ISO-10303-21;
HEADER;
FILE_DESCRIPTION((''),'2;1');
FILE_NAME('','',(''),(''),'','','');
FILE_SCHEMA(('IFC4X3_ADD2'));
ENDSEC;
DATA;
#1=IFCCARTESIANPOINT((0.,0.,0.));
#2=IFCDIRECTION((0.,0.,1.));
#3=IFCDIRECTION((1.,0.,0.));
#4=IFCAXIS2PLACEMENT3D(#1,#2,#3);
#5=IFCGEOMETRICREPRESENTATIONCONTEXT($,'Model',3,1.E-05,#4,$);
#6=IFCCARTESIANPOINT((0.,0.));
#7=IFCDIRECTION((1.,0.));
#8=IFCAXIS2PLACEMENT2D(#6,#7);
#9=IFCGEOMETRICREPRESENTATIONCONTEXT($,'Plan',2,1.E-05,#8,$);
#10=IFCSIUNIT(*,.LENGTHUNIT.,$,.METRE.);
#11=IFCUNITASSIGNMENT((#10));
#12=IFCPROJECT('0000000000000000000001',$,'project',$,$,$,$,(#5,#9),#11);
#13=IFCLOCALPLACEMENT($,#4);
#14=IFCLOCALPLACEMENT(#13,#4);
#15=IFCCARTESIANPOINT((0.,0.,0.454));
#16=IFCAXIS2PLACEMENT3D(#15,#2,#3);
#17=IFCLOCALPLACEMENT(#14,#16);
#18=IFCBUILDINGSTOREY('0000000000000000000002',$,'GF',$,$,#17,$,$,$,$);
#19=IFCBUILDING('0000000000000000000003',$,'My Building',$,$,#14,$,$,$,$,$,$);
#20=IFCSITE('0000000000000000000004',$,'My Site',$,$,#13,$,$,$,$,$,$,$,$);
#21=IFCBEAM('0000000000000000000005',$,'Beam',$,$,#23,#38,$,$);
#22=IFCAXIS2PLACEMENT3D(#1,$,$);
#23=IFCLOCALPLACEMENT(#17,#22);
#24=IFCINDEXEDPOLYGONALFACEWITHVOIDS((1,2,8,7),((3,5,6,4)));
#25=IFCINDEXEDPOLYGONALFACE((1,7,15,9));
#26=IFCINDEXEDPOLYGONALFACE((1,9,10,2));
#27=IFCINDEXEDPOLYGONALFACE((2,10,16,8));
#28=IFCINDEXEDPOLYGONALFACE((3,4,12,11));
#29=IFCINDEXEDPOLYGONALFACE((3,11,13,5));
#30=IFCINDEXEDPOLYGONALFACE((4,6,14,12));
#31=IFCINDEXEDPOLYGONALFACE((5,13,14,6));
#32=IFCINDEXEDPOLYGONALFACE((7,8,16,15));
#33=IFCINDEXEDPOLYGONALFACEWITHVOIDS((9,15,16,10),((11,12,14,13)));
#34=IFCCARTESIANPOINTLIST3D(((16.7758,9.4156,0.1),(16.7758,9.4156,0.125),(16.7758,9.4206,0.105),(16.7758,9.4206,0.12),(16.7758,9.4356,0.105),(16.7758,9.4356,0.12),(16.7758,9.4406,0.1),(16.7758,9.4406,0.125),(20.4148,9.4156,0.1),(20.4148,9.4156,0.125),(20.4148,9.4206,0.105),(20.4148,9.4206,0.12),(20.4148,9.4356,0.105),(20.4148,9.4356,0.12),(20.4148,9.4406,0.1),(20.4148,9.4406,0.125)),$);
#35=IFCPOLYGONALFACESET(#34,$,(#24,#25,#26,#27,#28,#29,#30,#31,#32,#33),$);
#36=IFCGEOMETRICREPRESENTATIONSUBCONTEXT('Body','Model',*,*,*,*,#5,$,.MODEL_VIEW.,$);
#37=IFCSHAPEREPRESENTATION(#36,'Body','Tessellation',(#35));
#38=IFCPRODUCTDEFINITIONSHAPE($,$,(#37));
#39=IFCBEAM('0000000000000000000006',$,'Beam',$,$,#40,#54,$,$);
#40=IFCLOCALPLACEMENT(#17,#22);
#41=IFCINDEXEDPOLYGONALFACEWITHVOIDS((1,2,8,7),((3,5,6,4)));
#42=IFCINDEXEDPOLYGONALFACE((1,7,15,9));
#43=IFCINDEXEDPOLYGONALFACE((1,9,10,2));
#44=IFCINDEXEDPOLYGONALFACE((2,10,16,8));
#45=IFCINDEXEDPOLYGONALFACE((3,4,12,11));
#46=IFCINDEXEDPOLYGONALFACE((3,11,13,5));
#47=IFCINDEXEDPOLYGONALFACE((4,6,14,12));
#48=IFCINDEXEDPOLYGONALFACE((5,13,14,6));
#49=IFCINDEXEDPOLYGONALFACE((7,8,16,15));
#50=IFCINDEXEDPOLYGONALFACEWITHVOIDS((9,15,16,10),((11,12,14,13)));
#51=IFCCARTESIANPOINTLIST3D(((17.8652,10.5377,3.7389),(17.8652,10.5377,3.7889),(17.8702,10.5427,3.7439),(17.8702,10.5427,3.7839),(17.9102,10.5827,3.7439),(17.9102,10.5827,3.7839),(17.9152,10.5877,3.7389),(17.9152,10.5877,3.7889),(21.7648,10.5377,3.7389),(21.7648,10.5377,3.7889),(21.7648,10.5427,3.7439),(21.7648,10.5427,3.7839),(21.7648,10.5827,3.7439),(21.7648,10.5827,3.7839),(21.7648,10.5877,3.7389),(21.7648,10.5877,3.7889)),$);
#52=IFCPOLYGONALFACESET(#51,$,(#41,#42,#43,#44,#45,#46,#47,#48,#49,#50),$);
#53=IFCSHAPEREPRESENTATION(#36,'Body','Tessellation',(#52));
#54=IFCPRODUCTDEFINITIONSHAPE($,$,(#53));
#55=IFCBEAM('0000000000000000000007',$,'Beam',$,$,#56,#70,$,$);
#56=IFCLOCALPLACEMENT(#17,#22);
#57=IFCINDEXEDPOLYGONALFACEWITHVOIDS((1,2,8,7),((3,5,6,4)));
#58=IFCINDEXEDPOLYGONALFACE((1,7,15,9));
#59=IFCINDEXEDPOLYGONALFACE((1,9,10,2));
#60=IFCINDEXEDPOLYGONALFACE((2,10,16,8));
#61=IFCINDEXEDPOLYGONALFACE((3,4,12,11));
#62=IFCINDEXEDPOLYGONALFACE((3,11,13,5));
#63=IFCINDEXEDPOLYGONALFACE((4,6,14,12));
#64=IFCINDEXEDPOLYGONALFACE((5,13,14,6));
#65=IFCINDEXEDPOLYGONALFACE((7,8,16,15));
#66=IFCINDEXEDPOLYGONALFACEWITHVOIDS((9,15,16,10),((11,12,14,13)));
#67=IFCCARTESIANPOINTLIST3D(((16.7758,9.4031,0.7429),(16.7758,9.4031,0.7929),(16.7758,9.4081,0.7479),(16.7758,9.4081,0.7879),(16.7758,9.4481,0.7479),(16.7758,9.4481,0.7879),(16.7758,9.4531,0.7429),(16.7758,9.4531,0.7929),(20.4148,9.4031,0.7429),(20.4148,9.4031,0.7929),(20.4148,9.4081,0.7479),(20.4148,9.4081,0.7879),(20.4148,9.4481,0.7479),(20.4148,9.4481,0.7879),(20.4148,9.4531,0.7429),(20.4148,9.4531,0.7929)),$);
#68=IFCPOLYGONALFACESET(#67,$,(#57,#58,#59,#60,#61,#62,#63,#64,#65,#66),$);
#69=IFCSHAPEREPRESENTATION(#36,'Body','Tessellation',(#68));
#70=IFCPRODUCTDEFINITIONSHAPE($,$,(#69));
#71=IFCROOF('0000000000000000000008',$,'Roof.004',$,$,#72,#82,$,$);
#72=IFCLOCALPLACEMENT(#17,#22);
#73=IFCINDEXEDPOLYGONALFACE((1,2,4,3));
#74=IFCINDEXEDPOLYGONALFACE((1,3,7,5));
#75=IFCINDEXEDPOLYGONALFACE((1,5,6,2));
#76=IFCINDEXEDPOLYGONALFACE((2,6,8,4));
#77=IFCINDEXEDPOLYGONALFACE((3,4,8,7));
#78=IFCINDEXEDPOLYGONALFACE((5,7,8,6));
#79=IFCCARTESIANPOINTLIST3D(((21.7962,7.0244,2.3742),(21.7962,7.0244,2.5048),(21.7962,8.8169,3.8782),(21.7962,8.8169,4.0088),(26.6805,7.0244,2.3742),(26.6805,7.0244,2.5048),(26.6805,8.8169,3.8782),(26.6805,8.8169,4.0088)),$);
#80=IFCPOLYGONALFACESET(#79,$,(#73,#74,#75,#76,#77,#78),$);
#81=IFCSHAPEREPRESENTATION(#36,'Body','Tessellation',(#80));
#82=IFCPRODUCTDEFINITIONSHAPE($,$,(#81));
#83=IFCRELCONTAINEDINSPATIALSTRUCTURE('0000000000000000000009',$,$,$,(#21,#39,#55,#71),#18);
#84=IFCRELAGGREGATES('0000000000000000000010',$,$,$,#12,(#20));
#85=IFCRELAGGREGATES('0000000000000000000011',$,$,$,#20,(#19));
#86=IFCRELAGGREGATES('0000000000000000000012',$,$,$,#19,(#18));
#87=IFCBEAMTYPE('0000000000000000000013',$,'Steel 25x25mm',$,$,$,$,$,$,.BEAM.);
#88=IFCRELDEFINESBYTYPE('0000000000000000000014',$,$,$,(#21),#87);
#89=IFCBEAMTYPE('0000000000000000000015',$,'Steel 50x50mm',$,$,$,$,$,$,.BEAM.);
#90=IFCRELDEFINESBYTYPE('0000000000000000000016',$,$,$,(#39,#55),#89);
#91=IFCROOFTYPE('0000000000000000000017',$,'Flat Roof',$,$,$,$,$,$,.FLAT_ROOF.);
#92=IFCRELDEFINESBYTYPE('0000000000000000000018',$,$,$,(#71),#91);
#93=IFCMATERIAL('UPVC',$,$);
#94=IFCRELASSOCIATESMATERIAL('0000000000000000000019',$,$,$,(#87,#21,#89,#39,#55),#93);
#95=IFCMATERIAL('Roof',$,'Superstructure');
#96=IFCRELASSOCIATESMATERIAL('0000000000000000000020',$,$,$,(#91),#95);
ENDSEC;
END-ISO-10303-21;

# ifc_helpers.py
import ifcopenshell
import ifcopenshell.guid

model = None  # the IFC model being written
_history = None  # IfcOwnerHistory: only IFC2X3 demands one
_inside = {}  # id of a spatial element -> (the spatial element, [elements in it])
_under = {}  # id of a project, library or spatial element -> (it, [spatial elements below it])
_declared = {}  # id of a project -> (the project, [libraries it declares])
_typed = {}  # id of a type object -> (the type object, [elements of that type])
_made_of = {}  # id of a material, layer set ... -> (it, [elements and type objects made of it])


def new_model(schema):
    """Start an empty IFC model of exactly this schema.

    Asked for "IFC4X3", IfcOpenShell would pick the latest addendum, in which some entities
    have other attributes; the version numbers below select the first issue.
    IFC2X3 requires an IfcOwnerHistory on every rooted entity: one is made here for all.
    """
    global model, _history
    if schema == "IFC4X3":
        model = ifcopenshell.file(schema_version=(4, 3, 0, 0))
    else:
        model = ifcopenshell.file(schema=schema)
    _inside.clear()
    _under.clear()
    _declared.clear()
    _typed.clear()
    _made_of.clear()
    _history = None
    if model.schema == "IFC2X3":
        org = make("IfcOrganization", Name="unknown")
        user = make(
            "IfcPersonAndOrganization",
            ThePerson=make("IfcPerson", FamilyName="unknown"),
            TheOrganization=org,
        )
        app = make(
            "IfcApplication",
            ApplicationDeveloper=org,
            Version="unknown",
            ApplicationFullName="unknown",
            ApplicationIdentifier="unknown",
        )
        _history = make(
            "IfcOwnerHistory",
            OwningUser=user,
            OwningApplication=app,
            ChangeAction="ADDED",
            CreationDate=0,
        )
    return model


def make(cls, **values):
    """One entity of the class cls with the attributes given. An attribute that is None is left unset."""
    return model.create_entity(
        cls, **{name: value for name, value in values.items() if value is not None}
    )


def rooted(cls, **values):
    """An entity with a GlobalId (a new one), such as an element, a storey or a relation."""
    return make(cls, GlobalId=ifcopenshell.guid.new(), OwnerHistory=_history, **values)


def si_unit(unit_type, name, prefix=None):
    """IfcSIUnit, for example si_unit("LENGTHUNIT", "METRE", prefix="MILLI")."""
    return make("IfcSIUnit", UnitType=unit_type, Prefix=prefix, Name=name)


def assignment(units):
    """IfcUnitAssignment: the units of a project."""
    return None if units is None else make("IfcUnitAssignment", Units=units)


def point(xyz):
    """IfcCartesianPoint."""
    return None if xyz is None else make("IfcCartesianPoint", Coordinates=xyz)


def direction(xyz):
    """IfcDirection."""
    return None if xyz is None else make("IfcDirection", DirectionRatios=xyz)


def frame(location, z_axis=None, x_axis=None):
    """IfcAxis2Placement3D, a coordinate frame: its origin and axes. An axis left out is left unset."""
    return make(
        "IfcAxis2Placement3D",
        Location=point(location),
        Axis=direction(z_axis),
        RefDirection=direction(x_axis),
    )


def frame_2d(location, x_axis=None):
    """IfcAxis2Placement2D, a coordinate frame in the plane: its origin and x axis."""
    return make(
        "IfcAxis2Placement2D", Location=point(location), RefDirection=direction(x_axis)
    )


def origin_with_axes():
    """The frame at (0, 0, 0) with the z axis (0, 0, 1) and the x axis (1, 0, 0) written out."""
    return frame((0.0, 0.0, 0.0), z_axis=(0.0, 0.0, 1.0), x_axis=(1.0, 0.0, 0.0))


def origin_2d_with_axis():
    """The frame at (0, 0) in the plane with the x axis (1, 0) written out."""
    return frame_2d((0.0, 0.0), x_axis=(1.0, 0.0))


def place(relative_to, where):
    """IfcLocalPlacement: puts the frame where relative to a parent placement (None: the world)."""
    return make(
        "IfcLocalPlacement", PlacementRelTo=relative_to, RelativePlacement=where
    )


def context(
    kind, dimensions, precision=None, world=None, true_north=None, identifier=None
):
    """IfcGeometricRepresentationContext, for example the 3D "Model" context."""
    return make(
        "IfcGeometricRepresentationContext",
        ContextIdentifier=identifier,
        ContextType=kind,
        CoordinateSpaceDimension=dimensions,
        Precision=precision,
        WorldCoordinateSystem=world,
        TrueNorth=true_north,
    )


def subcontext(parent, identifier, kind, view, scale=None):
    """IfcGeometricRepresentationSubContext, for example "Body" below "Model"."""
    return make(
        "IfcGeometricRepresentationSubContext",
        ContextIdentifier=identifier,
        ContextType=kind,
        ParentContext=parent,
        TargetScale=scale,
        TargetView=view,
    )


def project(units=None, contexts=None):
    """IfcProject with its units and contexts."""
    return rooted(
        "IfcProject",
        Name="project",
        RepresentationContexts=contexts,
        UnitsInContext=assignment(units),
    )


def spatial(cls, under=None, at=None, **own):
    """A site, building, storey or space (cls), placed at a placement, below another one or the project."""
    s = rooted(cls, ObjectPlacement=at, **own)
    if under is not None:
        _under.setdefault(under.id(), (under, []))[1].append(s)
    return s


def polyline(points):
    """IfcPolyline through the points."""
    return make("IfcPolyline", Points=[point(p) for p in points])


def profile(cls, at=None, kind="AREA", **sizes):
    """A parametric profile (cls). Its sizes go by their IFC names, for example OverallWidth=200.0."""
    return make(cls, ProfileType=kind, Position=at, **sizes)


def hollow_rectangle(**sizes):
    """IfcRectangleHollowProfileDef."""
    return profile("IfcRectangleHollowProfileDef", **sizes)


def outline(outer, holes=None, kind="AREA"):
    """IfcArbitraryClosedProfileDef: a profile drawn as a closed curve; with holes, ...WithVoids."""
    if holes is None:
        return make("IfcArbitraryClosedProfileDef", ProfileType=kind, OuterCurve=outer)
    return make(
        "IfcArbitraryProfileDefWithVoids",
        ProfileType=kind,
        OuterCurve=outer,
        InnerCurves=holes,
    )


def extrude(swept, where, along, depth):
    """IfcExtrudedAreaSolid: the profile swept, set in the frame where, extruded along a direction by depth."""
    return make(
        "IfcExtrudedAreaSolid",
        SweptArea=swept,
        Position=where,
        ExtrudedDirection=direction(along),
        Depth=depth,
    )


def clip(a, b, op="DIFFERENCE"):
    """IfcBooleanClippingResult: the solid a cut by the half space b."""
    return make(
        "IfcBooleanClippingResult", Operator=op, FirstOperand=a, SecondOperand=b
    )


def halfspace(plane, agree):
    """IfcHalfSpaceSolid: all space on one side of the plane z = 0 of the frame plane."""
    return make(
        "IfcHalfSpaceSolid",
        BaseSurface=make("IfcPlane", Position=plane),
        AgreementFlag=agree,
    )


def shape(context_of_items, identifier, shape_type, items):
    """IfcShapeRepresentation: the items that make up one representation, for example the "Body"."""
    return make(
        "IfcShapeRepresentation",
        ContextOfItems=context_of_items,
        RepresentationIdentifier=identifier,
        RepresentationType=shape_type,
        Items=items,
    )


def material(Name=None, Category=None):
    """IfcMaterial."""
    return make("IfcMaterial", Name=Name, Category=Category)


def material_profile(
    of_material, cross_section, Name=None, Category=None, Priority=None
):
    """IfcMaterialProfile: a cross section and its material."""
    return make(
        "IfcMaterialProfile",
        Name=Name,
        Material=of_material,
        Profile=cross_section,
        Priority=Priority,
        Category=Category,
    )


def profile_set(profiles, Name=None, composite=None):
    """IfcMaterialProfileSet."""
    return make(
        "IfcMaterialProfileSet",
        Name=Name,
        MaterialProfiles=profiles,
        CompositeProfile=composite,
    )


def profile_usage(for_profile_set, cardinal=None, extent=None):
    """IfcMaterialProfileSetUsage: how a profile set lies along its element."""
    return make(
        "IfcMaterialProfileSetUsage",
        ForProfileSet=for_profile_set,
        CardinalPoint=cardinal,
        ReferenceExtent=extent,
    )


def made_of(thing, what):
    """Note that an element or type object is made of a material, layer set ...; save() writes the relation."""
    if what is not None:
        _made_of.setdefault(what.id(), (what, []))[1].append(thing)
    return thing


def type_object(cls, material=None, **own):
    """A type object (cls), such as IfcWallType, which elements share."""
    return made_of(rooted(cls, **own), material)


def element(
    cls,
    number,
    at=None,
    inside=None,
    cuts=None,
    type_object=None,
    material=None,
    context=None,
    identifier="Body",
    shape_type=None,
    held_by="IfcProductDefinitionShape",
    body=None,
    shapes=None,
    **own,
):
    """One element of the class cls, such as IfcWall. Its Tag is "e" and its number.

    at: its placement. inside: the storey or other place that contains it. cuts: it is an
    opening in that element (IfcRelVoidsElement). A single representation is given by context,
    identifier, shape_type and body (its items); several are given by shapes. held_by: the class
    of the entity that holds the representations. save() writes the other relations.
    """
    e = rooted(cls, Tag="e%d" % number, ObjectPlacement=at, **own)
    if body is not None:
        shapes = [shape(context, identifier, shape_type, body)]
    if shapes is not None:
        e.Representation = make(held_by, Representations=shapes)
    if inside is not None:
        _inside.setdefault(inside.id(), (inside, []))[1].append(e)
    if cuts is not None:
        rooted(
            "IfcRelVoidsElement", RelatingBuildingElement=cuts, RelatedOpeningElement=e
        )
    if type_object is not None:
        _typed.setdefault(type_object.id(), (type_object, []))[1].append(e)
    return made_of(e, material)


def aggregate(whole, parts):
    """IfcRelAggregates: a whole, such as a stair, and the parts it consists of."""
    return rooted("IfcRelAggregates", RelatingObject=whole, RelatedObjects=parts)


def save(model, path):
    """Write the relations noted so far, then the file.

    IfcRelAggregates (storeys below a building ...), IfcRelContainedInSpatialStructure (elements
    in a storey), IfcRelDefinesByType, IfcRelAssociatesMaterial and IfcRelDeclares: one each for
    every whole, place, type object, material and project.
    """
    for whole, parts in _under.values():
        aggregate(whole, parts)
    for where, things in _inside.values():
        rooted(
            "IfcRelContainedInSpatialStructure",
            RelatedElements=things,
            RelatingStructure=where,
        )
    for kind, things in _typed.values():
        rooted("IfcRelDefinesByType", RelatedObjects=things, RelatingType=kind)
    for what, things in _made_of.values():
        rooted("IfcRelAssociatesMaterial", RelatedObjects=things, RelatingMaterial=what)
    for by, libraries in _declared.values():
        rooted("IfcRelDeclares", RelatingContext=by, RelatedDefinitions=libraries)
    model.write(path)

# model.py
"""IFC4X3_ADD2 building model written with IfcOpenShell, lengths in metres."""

from ifc_helpers import new_model, si_unit, frame, origin_with_axes, origin_2d_with_axis, place, context, subcontext, project, spatial, polyline, hollow_rectangle, outline, extrude, clip, halfspace, material, material_profile, profile_set, profile_usage, type_object, element, save


model = new_model("IFC4X3_ADD2")

# Units and contexts
model_context = context("Model", 3, precision=1e-05, world=origin_with_axes())
plan_context = context("Plan", 2, precision=1e-05, world=origin_2d_with_axis())
body_context = subcontext(model_context, "Body", "Model", "MODEL_VIEW")
ifc_project = project(units=[si_unit("LENGTHUNIT", "METRE")], contexts=[model_context, plan_context])

# Site, building, storey
site_placement = place(None, origin_with_axes())
site = spatial("IfcSite", under=ifc_project, at=site_placement, Name="My Site")
building_placement = place(site_placement, origin_with_axes())
building = spatial("IfcBuilding", under=site, at=building_placement, Name="My Building")
storey_placement = place(building_placement, frame((0.0, 0.0, 0.454), z_axis=(0.0, 0.0, 1.0), x_axis=(1.0, 0.0, 0.0)))
storey = spatial("IfcBuildingStorey", under=building, at=storey_placement, Name="GF")

# Shared definitions
ifc_material_1 = material(Name="UPVC")

# Beams
ifc_material_profile_1 = material_profile(ifc_material_1, hollow_rectangle(XDim=0.025, YDim=0.025, WallThickness=0.005))
ifc_profile_set_1 = profile_set([ifc_material_profile_1])
beam_type_1 = type_object("IfcBeamType", Name="Steel 25x25mm", PredefinedType="BEAM", material=ifc_profile_set_1)
ifc_profile_usage_1 = profile_usage(ifc_profile_set_1)
beam_1_placement = place(storey_placement, frame((16.7758, 9.4281, 0.1125), z_axis=(1.0, 0.0, 0.0), x_axis=(0.0, 1.0, 0.0)))
element("IfcBeam", 1, at=beam_1_placement, inside=storey, type_object=beam_type_1, material=ifc_profile_usage_1, Name="Beam", context=body_context, shape_type="SweptSolid", body=[
    extrude(hollow_rectangle(XDim=0.025, YDim=0.025, WallThickness=0.005), origin_with_axes(), (0.0, 0.0, 1.0), 3.6389),
])
ifc_material_profile_2 = material_profile(ifc_material_1, hollow_rectangle(XDim=0.05, YDim=0.05, WallThickness=0.005))
ifc_profile_set_2 = profile_set([ifc_material_profile_2])
ifc_profile_usage_2 = profile_usage(ifc_profile_set_2)
beam_type_2 = type_object("IfcBeamType", Name="Steel 50x50mm", PredefinedType="BEAM", material=ifc_profile_set_2)
beam_2_placement = place(storey_placement, frame((17.8652, 10.5627, 3.7639), z_axis=(1.0, 0.0, 0.0), x_axis=(0.0, 1.0, 0.0)))
element("IfcBeam", 2, at=beam_2_placement, inside=storey, type_object=beam_type_2, material=ifc_profile_usage_2, Name="Beam", context=body_context, shape_type="Clipping", body=[
    clip(extrude(hollow_rectangle(XDim=0.05, YDim=0.05, WallThickness=0.005), origin_with_axes(), (0.0, 0.0, 1.0), 3.8996), halfspace(frame((-0.025, -4.2179, 0.0), z_axis=(0.707107, 0.0, -0.707107), x_axis=(0.0, -1.0, 0.0)), False)),
])
ifc_profile_usage_3 = profile_usage(ifc_profile_set_2)
beam_3_placement = place(storey_placement, frame((16.7758, 9.4281, 0.7679), z_axis=(1.0, 0.0, 0.0), x_axis=(0.0, 1.0, 0.0)))
element("IfcBeam", 3, at=beam_3_placement, inside=storey, type_object=beam_type_2, material=ifc_profile_usage_3, Name="Beam", context=body_context, shape_type="SweptSolid", body=[
    extrude(hollow_rectangle(XDim=0.05, YDim=0.05, WallThickness=0.005), origin_with_axes(), (0.0, 0.0, 1.0), 3.6389),
])

# Roof
ifc_material_2 = material(Name="Roof", Category="Superstructure")
roof_type = type_object("IfcRoofType", Name="Flat Roof", PredefinedType="FLAT_ROOF", material=ifc_material_2)
roof_placement = place(storey_placement, frame((21.7962, 8.0241, 3.2131), z_axis=(0.0, -0.642788, 0.766044), x_axis=(1.0, 0.0, 0.0)))
element("IfcRoof", 4, at=roof_placement, inside=storey, type_object=roof_type, Name="Roof.004", context=body_context, shape_type="SweptSolid", body=[
    extrude(outline(polyline([(-2.4421, -0.0653), (2.4421, -0.0653), (2.4421, 0.0653), (-2.4421, 0.0653), (-2.4421, -0.0653)])), frame((2.4421, 1.0768, 0.05), z_axis=(0.0, 0.766044, -0.642788), x_axis=(1.0, 0.0, 0.0)), (0.0, 0.642788, -0.766044), 2.3398),
])

save(model, "model.ifc")
